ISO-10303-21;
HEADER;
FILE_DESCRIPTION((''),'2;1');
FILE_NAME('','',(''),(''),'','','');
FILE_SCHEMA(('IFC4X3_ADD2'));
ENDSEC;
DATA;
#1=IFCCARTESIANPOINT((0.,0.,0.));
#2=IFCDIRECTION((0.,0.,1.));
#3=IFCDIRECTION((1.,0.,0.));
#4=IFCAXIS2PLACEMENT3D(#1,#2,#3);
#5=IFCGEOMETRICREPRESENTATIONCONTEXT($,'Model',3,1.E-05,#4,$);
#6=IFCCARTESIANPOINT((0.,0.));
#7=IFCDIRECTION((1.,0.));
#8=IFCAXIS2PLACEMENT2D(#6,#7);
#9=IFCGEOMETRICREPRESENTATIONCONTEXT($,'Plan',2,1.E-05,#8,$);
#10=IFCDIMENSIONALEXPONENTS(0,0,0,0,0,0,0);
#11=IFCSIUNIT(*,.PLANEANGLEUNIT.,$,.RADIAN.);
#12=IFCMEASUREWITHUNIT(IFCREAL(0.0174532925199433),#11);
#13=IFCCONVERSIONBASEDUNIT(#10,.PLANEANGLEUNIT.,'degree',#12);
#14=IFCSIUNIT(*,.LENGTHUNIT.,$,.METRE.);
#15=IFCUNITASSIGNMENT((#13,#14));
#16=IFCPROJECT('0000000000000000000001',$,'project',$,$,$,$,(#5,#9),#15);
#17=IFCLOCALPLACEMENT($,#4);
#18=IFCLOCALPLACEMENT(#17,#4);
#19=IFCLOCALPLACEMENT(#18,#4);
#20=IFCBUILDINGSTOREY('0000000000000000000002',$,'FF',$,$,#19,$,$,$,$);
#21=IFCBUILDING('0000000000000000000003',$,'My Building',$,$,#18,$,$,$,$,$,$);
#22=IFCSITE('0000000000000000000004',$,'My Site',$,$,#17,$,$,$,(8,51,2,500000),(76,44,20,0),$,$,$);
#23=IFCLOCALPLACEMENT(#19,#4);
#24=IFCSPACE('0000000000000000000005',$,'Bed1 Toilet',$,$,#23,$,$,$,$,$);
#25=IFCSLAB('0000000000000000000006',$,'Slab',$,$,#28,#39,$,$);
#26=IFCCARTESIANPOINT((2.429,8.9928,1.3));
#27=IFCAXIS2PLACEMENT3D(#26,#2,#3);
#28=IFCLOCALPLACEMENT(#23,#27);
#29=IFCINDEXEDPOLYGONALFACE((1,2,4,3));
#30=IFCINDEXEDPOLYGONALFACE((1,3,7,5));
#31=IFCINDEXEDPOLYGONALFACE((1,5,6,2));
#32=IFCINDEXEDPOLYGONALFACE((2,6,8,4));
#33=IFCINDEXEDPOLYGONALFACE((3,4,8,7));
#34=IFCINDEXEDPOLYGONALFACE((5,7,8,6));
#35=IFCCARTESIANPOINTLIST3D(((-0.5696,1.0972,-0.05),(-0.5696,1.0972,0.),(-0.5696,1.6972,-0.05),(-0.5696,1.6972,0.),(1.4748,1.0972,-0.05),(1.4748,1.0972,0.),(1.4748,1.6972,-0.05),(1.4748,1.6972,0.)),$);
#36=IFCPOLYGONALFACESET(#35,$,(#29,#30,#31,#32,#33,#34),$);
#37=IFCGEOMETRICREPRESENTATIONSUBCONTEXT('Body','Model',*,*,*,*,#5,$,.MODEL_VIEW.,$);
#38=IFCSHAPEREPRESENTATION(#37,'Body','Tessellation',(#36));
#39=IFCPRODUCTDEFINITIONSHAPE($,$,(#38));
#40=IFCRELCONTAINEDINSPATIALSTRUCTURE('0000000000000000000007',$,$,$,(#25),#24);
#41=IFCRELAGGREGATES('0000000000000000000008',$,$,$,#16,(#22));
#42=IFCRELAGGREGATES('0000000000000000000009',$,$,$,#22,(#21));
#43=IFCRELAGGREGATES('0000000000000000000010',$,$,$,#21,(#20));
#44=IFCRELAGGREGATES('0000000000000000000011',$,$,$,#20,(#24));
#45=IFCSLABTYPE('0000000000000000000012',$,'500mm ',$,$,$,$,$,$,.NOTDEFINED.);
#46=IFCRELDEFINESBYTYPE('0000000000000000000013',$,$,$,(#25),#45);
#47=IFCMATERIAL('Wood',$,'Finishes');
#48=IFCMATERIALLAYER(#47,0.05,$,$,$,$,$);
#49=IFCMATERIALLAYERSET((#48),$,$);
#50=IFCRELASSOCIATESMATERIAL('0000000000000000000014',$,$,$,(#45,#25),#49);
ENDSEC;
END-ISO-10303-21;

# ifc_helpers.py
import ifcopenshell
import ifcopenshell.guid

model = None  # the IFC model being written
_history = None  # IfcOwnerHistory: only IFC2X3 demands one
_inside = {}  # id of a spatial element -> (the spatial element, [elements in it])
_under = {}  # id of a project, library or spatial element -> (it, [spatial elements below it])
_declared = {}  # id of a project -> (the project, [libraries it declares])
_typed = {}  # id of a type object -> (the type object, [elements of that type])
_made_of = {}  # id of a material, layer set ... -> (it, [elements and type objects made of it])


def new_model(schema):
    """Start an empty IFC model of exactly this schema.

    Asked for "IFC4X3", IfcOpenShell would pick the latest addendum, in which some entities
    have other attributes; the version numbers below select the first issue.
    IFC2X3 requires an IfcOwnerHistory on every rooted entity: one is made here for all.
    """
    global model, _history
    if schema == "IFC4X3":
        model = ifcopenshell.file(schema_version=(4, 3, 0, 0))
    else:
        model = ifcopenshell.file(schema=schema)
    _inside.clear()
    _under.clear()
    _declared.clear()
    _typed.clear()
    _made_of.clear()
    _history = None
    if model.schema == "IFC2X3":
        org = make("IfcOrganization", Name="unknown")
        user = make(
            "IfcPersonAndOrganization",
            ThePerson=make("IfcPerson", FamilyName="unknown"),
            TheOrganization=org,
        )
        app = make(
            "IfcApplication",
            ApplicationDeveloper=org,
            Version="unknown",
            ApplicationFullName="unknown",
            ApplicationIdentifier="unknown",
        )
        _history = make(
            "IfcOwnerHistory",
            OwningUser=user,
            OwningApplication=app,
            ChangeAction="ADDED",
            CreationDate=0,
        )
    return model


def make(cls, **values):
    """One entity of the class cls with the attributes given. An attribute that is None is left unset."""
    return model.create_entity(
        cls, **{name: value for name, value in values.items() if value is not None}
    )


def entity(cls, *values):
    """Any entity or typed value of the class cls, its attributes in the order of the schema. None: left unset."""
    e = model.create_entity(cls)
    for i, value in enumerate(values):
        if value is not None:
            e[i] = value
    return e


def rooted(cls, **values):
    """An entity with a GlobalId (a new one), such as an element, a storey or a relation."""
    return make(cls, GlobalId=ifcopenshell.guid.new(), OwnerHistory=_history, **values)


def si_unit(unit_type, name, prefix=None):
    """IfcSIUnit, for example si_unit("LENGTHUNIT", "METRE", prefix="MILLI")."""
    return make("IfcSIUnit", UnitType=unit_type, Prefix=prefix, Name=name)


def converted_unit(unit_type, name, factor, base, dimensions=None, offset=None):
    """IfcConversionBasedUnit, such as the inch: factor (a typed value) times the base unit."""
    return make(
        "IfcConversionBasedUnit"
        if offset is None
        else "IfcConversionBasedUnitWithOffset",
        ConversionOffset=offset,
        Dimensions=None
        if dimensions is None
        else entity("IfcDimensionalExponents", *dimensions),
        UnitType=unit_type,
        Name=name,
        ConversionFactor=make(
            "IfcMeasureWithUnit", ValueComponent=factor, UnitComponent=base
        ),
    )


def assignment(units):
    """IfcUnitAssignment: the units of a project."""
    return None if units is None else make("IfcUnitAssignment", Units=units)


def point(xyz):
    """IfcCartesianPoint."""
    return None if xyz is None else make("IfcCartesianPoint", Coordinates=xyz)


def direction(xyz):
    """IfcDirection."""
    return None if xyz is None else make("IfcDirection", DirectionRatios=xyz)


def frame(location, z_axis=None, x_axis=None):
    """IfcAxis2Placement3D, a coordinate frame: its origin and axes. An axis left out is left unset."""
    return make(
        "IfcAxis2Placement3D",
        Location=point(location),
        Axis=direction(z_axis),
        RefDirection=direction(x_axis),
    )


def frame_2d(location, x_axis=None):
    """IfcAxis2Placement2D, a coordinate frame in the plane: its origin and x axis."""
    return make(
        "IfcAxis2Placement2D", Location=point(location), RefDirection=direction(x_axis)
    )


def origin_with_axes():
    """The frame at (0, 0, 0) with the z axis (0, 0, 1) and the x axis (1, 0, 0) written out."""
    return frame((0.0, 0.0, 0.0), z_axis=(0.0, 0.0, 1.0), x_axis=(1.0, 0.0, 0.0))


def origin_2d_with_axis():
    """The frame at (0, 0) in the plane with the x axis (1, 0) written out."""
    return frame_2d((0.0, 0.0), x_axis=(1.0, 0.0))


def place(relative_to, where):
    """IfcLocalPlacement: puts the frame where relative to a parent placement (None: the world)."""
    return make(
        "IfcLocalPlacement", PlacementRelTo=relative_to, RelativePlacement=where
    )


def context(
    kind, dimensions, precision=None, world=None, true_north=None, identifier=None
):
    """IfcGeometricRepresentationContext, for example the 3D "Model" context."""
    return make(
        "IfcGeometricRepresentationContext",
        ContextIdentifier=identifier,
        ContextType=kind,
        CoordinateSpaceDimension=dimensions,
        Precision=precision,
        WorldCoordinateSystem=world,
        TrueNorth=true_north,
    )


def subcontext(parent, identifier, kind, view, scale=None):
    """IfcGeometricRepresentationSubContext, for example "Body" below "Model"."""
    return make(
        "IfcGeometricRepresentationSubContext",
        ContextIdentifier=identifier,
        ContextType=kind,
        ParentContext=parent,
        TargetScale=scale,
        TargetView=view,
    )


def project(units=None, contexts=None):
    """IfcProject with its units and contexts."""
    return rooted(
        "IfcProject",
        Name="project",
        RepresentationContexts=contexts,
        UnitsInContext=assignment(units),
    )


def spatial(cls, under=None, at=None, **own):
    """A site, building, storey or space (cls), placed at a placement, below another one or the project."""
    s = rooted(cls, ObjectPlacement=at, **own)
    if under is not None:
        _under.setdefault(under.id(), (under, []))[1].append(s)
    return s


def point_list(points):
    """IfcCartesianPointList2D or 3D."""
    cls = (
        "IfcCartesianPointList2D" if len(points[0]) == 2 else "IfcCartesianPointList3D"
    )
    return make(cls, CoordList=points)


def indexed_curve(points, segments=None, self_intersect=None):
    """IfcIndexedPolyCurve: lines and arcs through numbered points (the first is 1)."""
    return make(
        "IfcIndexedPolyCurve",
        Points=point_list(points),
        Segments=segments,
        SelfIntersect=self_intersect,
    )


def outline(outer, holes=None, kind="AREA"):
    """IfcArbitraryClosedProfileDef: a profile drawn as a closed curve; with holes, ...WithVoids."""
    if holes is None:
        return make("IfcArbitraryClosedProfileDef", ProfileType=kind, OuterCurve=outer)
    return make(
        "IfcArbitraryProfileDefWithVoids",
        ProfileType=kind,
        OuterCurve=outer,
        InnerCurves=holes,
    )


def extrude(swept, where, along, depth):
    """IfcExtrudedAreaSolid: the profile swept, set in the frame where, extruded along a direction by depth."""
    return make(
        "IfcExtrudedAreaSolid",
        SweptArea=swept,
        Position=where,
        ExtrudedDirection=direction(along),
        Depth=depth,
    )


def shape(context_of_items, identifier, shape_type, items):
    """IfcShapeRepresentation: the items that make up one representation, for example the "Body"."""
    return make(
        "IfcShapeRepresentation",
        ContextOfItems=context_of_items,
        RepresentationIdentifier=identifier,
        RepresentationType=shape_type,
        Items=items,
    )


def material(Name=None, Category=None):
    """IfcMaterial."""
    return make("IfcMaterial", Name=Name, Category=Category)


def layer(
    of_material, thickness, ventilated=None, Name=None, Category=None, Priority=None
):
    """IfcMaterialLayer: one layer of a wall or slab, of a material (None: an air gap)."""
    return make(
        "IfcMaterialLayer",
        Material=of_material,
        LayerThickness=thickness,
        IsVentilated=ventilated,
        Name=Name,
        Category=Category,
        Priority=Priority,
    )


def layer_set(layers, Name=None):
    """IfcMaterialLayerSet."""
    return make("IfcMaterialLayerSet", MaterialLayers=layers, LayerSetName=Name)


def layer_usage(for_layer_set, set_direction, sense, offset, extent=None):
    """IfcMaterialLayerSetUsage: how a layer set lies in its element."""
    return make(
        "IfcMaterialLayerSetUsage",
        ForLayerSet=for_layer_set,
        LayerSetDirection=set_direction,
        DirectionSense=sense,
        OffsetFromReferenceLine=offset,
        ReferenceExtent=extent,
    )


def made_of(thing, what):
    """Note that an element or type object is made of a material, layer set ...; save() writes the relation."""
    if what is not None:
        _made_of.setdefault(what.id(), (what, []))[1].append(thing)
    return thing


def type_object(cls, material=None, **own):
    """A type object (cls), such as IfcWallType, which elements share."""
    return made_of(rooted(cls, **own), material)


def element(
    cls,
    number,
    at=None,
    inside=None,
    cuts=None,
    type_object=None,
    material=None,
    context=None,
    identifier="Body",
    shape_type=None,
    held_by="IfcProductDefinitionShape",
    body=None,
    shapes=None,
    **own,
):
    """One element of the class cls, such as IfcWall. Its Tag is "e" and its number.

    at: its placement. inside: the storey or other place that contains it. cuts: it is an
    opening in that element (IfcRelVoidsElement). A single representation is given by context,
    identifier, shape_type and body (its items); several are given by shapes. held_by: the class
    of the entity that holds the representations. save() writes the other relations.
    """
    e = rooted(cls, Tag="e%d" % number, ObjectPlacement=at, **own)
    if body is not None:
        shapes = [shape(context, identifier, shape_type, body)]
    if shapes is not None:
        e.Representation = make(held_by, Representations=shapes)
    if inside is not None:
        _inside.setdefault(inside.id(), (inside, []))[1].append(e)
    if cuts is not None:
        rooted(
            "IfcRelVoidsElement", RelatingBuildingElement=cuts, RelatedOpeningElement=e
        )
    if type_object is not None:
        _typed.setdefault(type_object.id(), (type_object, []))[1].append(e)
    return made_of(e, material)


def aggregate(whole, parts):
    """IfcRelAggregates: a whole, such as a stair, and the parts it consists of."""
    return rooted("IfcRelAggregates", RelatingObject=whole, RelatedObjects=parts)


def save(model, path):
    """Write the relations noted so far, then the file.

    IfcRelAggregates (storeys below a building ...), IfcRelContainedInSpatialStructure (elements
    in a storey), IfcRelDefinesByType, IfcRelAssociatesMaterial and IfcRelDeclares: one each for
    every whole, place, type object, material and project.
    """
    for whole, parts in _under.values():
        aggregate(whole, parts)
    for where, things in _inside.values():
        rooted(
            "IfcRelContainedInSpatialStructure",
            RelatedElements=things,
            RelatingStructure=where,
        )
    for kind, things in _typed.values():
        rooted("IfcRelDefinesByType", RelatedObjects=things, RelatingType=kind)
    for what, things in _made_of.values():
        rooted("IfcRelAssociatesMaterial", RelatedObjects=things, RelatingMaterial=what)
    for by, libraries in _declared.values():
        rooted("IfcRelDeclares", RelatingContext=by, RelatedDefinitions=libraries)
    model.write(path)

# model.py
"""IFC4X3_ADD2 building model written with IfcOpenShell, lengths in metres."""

from ifc_helpers import new_model, entity, si_unit, converted_unit, frame, origin_with_axes, origin_2d_with_axis, place, context, subcontext, project, spatial, indexed_curve, outline, extrude, material, layer, layer_set, layer_usage, type_object, element, save


model = new_model("IFC4X3_ADD2")

# Units and contexts
model_context = context("Model", 3, precision=1e-05, world=origin_with_axes())
plan_context = context("Plan", 2, precision=1e-05, world=origin_2d_with_axis())
body_context_1 = subcontext(model_context, "Body", "Model", "MODEL_VIEW")
ifc_project = project(units=[converted_unit("PLANEANGLEUNIT", "degree", entity("IfcReal", 0.0174532925199433), si_unit("PLANEANGLEUNIT", "RADIAN"), dimensions=[0, 0, 0, 0, 0, 0, 0]), si_unit("LENGTHUNIT", "METRE")], contexts=[model_context, plan_context])

# Site, building, storey
site_placement = place(None, origin_with_axes())
site = spatial("IfcSite", under=ifc_project, at=site_placement, Name="My Site", RefLatitude=(8, 51, 2, 500000), RefLongitude=(76, 44, 20, 0))
building_placement = place(site_placement, origin_with_axes())
building = spatial("IfcBuilding", under=site, at=building_placement, Name="My Building")
storey_placement = place(building_placement, origin_with_axes())
storey = spatial("IfcBuildingStorey", under=building, at=storey_placement, Name="FF")

# Shared definitions
space_1_placement = place(storey_placement, origin_with_axes())
space_1 = spatial("IfcSpace", under=storey, at=space_1_placement, Name="Bed1 Toilet")

# Slab
ifc_material_1 = material(Name="Wood", Category="Finishes")
ifc_layer_1 = layer(ifc_material_1, 0.05)
ifc_layer_set_1 = layer_set([ifc_layer_1])
ifc_layer_usage_1 = layer_usage(ifc_layer_set_1, "AXIS3", "POSITIVE", -0.05)
slab_type = type_object("IfcSlabType", Name="500mm ", PredefinedType="NOTDEFINED", material=ifc_layer_set_1)
slab_placement = place(space_1_placement, frame((2.429, 8.9928, 1.3), z_axis=(0.0, 0.0, 1.0), x_axis=(1.0, 0.0, 0.0)))
element("IfcSlab", 1, at=slab_placement, inside=space_1, type_object=slab_type, material=ifc_layer_usage_1, Name="Slab", context=body_context_1, shape_type="SweptSolid", body=[
    extrude(outline(indexed_curve([(1.4748, 1.0972), (1.4748, 1.6972), (-0.5696, 1.6972), (-0.5696, 1.0972), (1.4748, 1.0972)])), frame((0.0, 0.0, -0.05), z_axis=(0.0, 0.0, 1.0), x_axis=(1.0, 0.0, 0.0)), (0.0, 0.0, 1.0), 0.05),
])

save(model, "model.ifc")
